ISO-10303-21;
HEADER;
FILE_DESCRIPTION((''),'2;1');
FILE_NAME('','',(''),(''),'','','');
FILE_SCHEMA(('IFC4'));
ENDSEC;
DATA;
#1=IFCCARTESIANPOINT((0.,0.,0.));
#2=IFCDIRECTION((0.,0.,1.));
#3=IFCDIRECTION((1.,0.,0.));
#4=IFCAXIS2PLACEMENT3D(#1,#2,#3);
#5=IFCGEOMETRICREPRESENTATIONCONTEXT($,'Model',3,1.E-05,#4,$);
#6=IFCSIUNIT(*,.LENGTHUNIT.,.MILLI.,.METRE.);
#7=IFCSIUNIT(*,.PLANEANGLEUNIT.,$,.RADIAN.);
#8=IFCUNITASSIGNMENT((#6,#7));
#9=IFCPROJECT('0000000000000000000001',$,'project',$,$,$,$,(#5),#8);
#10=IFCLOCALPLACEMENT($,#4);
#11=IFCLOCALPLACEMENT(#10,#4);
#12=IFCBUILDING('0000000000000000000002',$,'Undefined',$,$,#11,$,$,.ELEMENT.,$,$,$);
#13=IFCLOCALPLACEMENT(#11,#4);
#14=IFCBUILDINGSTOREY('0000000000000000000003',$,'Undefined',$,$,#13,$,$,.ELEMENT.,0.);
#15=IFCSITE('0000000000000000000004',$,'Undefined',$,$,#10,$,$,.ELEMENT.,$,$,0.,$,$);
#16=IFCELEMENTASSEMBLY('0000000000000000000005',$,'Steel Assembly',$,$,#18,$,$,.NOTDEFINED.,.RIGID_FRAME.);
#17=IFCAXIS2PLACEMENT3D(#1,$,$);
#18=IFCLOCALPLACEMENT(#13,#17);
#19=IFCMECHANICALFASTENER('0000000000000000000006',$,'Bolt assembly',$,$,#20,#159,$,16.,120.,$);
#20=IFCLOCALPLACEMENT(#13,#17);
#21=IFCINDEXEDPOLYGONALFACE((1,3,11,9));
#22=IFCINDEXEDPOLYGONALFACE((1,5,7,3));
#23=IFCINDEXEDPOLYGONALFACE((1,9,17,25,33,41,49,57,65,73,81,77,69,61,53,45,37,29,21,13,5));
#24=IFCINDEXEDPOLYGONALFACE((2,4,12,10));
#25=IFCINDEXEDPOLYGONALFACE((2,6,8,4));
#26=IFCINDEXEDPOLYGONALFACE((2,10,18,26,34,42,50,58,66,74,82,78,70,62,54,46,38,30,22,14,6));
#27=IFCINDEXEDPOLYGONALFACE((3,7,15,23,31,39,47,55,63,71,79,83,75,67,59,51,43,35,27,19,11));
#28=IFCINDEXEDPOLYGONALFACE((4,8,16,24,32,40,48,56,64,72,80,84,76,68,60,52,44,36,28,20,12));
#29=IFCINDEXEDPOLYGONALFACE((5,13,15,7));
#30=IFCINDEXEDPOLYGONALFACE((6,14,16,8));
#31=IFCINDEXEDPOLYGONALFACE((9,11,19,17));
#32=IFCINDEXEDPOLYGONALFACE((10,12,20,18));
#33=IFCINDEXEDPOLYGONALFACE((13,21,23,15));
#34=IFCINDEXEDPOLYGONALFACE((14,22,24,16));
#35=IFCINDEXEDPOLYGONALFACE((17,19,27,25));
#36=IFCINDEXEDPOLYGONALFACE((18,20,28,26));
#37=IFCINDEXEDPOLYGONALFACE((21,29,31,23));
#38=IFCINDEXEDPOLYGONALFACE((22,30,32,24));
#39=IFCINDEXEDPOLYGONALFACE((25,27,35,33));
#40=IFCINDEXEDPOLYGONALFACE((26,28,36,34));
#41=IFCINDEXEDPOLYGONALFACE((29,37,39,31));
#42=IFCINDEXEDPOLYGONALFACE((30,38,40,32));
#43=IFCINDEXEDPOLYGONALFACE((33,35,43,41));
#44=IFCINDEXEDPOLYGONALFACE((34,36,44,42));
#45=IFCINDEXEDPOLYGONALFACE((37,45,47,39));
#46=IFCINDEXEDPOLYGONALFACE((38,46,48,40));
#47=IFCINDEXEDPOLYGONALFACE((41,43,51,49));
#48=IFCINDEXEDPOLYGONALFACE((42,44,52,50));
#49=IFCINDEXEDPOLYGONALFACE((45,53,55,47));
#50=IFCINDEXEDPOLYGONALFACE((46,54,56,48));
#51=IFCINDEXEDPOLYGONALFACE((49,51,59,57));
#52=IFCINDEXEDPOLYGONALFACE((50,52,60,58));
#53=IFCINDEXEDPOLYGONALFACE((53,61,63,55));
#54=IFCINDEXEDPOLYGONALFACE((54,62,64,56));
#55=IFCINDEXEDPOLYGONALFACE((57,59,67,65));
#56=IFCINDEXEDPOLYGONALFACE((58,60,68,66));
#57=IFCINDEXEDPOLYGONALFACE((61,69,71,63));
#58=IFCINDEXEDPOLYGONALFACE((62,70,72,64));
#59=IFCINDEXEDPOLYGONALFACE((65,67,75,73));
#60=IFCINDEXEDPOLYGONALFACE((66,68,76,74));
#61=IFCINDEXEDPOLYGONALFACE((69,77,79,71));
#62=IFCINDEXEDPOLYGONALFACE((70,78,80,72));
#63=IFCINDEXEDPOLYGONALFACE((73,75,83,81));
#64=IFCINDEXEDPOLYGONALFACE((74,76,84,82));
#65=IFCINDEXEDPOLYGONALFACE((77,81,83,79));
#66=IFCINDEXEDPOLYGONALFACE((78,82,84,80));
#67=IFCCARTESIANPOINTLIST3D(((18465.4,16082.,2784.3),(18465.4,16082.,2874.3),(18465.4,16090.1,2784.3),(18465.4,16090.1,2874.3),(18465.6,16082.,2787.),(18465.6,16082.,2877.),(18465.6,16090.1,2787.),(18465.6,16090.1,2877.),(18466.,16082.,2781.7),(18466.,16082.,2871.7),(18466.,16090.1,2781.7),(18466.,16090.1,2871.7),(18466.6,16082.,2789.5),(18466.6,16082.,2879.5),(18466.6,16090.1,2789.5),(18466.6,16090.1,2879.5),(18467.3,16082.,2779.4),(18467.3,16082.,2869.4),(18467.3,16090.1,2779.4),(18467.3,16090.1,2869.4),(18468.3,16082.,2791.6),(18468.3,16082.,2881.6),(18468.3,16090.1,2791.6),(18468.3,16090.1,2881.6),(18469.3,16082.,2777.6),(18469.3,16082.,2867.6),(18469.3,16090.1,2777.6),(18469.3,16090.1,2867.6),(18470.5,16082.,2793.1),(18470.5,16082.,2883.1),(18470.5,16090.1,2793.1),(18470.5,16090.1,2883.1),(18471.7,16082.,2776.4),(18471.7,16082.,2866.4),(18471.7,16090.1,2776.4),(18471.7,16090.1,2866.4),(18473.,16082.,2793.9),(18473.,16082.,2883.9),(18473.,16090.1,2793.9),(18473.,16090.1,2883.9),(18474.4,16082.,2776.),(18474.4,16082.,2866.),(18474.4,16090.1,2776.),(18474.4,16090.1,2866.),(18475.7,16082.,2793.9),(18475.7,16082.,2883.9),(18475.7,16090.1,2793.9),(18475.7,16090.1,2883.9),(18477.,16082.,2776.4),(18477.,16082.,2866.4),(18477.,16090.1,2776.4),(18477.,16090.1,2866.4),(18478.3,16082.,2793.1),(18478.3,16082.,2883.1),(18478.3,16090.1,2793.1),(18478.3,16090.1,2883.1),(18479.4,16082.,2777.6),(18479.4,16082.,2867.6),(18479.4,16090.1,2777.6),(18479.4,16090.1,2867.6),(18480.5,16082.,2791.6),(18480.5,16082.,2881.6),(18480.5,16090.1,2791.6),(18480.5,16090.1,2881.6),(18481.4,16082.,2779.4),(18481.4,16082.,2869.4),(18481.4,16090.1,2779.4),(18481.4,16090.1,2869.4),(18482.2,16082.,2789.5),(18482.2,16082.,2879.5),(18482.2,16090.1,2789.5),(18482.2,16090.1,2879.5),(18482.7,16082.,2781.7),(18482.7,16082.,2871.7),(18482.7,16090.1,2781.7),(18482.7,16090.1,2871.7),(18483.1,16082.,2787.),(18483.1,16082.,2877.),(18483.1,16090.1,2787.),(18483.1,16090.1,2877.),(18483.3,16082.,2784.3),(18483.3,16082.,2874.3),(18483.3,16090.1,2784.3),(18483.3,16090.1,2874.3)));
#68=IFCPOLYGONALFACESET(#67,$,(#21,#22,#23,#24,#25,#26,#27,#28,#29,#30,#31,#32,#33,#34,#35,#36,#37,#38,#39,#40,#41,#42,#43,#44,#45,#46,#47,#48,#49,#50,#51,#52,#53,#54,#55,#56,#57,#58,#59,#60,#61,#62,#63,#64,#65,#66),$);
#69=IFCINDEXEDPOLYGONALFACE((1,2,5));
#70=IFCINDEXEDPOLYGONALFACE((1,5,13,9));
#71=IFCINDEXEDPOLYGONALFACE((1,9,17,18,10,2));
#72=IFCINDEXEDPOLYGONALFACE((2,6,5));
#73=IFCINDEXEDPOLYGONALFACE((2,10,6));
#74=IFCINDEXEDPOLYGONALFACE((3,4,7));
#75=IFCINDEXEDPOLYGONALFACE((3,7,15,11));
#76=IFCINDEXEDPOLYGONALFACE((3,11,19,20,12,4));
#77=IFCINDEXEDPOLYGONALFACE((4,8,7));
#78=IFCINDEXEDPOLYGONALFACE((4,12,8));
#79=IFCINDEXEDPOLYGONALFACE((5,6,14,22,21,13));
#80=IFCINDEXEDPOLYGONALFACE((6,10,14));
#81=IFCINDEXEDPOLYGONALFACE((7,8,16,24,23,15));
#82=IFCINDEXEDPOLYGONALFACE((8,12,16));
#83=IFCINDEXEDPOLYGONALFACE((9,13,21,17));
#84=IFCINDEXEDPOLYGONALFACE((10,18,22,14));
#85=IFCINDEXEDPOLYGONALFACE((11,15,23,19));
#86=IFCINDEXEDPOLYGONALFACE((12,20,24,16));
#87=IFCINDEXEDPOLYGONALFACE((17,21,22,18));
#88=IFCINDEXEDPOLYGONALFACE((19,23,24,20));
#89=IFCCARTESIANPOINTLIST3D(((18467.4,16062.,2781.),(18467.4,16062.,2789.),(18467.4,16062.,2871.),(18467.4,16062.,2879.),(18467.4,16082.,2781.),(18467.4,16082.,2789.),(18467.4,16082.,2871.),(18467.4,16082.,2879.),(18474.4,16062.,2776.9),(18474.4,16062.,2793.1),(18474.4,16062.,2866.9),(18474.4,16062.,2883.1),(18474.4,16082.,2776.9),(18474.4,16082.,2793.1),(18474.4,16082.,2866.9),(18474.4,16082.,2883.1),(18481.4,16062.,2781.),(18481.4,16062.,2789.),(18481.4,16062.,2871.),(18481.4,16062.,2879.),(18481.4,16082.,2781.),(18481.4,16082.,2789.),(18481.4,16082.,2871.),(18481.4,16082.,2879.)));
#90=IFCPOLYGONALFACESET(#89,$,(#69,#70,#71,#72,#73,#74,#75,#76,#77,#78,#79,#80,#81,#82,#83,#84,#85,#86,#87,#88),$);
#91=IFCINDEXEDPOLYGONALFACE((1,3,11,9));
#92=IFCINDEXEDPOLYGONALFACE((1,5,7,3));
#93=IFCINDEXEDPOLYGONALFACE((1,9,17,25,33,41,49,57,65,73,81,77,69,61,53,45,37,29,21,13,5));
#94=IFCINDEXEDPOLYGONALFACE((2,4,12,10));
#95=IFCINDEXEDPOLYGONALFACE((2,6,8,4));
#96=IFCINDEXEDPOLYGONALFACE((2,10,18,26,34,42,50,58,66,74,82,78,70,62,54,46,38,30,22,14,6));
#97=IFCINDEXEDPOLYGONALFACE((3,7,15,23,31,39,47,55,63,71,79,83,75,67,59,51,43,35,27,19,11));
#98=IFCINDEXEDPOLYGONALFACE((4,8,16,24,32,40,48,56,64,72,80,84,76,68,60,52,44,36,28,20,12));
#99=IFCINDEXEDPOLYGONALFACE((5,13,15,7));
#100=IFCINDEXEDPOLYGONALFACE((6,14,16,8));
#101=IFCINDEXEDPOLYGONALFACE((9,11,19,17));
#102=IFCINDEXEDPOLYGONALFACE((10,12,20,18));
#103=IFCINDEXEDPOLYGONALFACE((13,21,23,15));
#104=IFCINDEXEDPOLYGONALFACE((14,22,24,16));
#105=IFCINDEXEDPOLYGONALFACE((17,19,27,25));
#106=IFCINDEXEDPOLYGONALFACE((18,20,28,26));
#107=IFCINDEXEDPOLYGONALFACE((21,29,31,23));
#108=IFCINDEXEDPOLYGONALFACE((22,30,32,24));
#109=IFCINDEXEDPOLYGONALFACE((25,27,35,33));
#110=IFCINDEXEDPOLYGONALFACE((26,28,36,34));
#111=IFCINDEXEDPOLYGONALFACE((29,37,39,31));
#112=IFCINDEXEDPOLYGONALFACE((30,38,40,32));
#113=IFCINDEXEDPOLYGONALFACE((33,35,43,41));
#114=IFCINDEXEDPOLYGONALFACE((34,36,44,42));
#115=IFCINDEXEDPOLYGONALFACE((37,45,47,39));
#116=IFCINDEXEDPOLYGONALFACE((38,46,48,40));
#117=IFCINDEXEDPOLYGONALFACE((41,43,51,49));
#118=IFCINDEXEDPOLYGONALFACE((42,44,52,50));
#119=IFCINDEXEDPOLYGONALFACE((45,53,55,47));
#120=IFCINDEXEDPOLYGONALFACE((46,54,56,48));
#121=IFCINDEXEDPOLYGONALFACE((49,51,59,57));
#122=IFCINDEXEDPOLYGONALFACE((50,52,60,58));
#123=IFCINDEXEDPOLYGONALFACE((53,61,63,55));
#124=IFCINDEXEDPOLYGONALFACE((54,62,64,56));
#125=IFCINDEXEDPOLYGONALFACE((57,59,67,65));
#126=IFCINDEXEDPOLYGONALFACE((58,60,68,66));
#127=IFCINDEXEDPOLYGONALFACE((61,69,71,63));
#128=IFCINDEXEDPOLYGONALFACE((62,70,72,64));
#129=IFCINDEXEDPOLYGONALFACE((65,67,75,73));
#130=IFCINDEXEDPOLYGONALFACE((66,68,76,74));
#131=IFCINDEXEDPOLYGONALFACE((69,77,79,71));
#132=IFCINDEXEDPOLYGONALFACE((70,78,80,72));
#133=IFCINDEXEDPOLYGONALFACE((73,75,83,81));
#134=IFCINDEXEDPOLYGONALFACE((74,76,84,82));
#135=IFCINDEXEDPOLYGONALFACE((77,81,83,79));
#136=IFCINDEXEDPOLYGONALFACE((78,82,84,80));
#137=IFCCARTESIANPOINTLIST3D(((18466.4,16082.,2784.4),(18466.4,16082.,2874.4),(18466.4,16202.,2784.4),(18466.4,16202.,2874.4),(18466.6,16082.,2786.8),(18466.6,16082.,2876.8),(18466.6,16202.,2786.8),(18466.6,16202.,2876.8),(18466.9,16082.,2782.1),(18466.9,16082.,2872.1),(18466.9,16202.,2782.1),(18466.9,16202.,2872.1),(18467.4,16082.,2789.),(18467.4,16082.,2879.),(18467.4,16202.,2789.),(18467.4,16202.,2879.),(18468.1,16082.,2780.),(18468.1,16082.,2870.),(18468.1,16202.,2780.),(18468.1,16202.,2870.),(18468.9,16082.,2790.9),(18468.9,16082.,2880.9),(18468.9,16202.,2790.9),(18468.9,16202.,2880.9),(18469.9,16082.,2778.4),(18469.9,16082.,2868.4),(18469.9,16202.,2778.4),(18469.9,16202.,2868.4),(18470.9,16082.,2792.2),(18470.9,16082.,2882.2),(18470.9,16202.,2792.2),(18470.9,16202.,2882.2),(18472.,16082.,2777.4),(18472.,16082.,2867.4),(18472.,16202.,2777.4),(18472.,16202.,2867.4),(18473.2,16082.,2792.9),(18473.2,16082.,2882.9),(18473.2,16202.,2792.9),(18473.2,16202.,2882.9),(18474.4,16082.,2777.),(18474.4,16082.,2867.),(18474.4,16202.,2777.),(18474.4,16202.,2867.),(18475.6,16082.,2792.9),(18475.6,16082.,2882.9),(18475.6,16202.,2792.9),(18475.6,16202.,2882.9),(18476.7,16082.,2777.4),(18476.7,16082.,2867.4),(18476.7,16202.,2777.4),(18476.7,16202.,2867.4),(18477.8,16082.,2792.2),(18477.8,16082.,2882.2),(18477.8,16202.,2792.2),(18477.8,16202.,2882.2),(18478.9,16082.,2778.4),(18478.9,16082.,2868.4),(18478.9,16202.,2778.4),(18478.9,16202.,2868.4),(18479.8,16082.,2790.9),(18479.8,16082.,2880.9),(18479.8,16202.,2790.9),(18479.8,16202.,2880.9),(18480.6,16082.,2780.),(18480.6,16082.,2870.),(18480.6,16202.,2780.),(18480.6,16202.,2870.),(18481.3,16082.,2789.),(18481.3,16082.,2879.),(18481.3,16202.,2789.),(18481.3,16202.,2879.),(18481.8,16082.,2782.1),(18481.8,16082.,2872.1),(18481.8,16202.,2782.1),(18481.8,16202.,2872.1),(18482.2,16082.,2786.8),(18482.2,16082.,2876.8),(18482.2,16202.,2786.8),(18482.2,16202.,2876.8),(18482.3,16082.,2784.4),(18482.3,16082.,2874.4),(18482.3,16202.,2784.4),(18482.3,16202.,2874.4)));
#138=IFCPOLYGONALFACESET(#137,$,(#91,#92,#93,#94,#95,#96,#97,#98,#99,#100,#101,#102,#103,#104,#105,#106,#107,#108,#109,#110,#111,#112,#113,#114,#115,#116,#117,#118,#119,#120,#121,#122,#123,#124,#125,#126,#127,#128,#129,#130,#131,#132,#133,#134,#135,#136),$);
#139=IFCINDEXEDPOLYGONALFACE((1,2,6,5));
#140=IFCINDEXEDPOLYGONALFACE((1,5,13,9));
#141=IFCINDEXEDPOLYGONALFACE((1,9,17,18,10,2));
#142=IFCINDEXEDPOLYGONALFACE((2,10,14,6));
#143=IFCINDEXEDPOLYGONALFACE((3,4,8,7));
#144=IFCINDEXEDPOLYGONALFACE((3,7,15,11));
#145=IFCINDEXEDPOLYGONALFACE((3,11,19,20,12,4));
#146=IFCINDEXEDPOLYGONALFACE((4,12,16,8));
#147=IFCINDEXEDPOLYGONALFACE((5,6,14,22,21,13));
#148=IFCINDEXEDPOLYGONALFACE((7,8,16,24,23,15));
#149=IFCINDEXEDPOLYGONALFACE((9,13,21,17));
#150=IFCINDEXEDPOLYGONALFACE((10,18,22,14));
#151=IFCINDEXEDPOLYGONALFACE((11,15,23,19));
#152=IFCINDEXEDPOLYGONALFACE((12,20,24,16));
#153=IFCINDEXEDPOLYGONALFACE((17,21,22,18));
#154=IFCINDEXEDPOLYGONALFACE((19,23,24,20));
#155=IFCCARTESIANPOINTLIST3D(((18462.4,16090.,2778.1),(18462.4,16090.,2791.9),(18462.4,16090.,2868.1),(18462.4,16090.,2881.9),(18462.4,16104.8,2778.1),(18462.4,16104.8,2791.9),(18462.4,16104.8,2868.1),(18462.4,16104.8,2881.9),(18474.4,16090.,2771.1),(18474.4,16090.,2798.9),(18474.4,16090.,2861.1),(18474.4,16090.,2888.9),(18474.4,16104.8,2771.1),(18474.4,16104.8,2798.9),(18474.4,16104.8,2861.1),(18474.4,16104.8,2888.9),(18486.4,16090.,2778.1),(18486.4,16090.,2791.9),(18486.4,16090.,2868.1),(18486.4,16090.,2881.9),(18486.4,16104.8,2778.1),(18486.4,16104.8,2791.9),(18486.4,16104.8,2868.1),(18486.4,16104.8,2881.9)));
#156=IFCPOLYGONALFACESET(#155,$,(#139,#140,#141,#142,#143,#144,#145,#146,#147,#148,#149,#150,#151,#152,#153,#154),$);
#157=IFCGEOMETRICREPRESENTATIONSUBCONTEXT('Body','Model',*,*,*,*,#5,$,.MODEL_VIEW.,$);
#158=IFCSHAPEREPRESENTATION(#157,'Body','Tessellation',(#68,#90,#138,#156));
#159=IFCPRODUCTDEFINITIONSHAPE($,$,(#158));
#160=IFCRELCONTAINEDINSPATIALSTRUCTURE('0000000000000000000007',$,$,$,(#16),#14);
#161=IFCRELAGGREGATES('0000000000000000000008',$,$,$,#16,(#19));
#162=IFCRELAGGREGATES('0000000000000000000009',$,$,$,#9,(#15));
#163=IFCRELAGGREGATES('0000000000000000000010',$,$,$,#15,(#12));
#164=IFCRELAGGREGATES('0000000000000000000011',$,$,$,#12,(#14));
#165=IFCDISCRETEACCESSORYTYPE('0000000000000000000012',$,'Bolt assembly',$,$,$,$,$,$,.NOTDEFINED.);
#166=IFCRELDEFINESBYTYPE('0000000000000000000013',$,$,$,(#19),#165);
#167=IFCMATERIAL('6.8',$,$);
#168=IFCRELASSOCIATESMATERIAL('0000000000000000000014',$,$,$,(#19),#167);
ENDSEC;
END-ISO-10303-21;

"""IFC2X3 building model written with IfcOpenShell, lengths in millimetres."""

from ifc_helpers import new_model, si_unit, frame, origin_with_axes, origin_2d_with_axis, place, context, subcontext, project, spatial, polyline, circle, outline, extrude, source, transform, mapped, material, type_object, element, aggregate, save


model = new_model("IFC2X3")

# Units and contexts
model_context = context("Model", 3, precision=1e-05, world=origin_with_axes())
body_context = subcontext(model_context, "Body", "Model", "MODEL_VIEW")
ifc_project = project(units=[si_unit("LENGTHUNIT", "METRE", prefix="MILLI"), si_unit("PLANEANGLEUNIT", "RADIAN")], contexts=[model_context])

# Site, building, storey
site_placement = place(None, origin_with_axes())
site = spatial("IfcSite", under=ifc_project, at=site_placement, Name="Undefined", CompositionType="ELEMENT", RefElevation=0.0)
building_placement = place(site_placement, origin_with_axes())
building = spatial("IfcBuilding", under=site, at=building_placement, Name="Undefined", CompositionType="ELEMENT")
storey_placement = place(building_placement, origin_with_axes())
storey = spatial("IfcBuildingStorey", under=building, at=storey_placement, Name="Undefined", CompositionType="ELEMENT", Elevation=0.0)

# Shared definitions
ifc_material_1 = material(Name="6.8")
discrete_accessory_type_1 = type_object("IfcDiscreteAccessoryType", Name="Bolt assembly")
shared_shape_1 = source(origin_with_axes(), body_context, "Body", "SweptSolid", [
    extrude(circle(Radius=9.0, at=origin_2d_with_axis()), frame((0.0, -8.0, 0.0), z_axis=(0.0, 1.0, 0.0), x_axis=(1.0, 0.0, 0.0)), (0.0, 0.0, 1.0), 8.1),
    extrude(outline(polyline([(8.1, 0.0), (4.0, 7.0), (-4.0, 7.0), (-8.1, 0.0), (-4.0, -7.0), (4.0, -7.0), (8.1, 0.0)])), frame((0.0, -28.0, 0.0), z_axis=(0.0, 1.0, 0.0), x_axis=(1.0, 0.0, 0.0)), (0.0, 0.0, 1.0), 20.0),
    extrude(circle(Radius=8.0, at=origin_2d_with_axis()), frame((0.0, -8.0, 0.0), z_axis=(0.0, 1.0, 0.0), x_axis=(1.0, 0.0, 0.0)), (0.0, 0.0, 1.0), 120.0),
    extrude(outline(polyline([(13.9, 0.0), (6.9, 12.0), (-6.9, 12.0), (-13.9, 0.0), (-6.9, -12.0), (6.9, -12.0), (13.9, 0.0)])), frame((0.0, 0.0, 0.0), z_axis=(0.0, 1.0, 0.0), x_axis=(1.0, 0.0, 0.0)), (0.0, 0.0, 1.0), 14.8),
])

# Element assembly, mechanical fastener
assembly_1_placement = place(storey_placement, origin_with_axes())
assembly_1 = element("IfcElementAssembly", 1, at=assembly_1_placement, inside=storey, Name="Steel Assembly", AssemblyPlace="NOTDEFINED", PredefinedType="RIGID_FRAME")
mechanical_fastener_1_placement = place(assembly_1_placement, frame((18474.4, 16090.0, 2875.0), z_axis=(1.0, 0.0, 0.0), x_axis=(0.0, 0.0, -1.0)))
mechanical_fastener_1 = element("IfcMechanicalFastener", 2, at=mechanical_fastener_1_placement, type_object=discrete_accessory_type_1, material=ifc_material_1, Name="Bolt assembly", NominalDiameter=16.0, NominalLength=120.0, context=body_context, shape_type="MappedRepresentation", body=[
    mapped(shared_shape_1, transform((0.0, 0.0, 0.0))),
    mapped(shared_shape_1, transform((90.0, 0.0, 0.0))),
])

aggregate(assembly_1, [mechanical_fastener_1])

save(model, "model.ifc")
